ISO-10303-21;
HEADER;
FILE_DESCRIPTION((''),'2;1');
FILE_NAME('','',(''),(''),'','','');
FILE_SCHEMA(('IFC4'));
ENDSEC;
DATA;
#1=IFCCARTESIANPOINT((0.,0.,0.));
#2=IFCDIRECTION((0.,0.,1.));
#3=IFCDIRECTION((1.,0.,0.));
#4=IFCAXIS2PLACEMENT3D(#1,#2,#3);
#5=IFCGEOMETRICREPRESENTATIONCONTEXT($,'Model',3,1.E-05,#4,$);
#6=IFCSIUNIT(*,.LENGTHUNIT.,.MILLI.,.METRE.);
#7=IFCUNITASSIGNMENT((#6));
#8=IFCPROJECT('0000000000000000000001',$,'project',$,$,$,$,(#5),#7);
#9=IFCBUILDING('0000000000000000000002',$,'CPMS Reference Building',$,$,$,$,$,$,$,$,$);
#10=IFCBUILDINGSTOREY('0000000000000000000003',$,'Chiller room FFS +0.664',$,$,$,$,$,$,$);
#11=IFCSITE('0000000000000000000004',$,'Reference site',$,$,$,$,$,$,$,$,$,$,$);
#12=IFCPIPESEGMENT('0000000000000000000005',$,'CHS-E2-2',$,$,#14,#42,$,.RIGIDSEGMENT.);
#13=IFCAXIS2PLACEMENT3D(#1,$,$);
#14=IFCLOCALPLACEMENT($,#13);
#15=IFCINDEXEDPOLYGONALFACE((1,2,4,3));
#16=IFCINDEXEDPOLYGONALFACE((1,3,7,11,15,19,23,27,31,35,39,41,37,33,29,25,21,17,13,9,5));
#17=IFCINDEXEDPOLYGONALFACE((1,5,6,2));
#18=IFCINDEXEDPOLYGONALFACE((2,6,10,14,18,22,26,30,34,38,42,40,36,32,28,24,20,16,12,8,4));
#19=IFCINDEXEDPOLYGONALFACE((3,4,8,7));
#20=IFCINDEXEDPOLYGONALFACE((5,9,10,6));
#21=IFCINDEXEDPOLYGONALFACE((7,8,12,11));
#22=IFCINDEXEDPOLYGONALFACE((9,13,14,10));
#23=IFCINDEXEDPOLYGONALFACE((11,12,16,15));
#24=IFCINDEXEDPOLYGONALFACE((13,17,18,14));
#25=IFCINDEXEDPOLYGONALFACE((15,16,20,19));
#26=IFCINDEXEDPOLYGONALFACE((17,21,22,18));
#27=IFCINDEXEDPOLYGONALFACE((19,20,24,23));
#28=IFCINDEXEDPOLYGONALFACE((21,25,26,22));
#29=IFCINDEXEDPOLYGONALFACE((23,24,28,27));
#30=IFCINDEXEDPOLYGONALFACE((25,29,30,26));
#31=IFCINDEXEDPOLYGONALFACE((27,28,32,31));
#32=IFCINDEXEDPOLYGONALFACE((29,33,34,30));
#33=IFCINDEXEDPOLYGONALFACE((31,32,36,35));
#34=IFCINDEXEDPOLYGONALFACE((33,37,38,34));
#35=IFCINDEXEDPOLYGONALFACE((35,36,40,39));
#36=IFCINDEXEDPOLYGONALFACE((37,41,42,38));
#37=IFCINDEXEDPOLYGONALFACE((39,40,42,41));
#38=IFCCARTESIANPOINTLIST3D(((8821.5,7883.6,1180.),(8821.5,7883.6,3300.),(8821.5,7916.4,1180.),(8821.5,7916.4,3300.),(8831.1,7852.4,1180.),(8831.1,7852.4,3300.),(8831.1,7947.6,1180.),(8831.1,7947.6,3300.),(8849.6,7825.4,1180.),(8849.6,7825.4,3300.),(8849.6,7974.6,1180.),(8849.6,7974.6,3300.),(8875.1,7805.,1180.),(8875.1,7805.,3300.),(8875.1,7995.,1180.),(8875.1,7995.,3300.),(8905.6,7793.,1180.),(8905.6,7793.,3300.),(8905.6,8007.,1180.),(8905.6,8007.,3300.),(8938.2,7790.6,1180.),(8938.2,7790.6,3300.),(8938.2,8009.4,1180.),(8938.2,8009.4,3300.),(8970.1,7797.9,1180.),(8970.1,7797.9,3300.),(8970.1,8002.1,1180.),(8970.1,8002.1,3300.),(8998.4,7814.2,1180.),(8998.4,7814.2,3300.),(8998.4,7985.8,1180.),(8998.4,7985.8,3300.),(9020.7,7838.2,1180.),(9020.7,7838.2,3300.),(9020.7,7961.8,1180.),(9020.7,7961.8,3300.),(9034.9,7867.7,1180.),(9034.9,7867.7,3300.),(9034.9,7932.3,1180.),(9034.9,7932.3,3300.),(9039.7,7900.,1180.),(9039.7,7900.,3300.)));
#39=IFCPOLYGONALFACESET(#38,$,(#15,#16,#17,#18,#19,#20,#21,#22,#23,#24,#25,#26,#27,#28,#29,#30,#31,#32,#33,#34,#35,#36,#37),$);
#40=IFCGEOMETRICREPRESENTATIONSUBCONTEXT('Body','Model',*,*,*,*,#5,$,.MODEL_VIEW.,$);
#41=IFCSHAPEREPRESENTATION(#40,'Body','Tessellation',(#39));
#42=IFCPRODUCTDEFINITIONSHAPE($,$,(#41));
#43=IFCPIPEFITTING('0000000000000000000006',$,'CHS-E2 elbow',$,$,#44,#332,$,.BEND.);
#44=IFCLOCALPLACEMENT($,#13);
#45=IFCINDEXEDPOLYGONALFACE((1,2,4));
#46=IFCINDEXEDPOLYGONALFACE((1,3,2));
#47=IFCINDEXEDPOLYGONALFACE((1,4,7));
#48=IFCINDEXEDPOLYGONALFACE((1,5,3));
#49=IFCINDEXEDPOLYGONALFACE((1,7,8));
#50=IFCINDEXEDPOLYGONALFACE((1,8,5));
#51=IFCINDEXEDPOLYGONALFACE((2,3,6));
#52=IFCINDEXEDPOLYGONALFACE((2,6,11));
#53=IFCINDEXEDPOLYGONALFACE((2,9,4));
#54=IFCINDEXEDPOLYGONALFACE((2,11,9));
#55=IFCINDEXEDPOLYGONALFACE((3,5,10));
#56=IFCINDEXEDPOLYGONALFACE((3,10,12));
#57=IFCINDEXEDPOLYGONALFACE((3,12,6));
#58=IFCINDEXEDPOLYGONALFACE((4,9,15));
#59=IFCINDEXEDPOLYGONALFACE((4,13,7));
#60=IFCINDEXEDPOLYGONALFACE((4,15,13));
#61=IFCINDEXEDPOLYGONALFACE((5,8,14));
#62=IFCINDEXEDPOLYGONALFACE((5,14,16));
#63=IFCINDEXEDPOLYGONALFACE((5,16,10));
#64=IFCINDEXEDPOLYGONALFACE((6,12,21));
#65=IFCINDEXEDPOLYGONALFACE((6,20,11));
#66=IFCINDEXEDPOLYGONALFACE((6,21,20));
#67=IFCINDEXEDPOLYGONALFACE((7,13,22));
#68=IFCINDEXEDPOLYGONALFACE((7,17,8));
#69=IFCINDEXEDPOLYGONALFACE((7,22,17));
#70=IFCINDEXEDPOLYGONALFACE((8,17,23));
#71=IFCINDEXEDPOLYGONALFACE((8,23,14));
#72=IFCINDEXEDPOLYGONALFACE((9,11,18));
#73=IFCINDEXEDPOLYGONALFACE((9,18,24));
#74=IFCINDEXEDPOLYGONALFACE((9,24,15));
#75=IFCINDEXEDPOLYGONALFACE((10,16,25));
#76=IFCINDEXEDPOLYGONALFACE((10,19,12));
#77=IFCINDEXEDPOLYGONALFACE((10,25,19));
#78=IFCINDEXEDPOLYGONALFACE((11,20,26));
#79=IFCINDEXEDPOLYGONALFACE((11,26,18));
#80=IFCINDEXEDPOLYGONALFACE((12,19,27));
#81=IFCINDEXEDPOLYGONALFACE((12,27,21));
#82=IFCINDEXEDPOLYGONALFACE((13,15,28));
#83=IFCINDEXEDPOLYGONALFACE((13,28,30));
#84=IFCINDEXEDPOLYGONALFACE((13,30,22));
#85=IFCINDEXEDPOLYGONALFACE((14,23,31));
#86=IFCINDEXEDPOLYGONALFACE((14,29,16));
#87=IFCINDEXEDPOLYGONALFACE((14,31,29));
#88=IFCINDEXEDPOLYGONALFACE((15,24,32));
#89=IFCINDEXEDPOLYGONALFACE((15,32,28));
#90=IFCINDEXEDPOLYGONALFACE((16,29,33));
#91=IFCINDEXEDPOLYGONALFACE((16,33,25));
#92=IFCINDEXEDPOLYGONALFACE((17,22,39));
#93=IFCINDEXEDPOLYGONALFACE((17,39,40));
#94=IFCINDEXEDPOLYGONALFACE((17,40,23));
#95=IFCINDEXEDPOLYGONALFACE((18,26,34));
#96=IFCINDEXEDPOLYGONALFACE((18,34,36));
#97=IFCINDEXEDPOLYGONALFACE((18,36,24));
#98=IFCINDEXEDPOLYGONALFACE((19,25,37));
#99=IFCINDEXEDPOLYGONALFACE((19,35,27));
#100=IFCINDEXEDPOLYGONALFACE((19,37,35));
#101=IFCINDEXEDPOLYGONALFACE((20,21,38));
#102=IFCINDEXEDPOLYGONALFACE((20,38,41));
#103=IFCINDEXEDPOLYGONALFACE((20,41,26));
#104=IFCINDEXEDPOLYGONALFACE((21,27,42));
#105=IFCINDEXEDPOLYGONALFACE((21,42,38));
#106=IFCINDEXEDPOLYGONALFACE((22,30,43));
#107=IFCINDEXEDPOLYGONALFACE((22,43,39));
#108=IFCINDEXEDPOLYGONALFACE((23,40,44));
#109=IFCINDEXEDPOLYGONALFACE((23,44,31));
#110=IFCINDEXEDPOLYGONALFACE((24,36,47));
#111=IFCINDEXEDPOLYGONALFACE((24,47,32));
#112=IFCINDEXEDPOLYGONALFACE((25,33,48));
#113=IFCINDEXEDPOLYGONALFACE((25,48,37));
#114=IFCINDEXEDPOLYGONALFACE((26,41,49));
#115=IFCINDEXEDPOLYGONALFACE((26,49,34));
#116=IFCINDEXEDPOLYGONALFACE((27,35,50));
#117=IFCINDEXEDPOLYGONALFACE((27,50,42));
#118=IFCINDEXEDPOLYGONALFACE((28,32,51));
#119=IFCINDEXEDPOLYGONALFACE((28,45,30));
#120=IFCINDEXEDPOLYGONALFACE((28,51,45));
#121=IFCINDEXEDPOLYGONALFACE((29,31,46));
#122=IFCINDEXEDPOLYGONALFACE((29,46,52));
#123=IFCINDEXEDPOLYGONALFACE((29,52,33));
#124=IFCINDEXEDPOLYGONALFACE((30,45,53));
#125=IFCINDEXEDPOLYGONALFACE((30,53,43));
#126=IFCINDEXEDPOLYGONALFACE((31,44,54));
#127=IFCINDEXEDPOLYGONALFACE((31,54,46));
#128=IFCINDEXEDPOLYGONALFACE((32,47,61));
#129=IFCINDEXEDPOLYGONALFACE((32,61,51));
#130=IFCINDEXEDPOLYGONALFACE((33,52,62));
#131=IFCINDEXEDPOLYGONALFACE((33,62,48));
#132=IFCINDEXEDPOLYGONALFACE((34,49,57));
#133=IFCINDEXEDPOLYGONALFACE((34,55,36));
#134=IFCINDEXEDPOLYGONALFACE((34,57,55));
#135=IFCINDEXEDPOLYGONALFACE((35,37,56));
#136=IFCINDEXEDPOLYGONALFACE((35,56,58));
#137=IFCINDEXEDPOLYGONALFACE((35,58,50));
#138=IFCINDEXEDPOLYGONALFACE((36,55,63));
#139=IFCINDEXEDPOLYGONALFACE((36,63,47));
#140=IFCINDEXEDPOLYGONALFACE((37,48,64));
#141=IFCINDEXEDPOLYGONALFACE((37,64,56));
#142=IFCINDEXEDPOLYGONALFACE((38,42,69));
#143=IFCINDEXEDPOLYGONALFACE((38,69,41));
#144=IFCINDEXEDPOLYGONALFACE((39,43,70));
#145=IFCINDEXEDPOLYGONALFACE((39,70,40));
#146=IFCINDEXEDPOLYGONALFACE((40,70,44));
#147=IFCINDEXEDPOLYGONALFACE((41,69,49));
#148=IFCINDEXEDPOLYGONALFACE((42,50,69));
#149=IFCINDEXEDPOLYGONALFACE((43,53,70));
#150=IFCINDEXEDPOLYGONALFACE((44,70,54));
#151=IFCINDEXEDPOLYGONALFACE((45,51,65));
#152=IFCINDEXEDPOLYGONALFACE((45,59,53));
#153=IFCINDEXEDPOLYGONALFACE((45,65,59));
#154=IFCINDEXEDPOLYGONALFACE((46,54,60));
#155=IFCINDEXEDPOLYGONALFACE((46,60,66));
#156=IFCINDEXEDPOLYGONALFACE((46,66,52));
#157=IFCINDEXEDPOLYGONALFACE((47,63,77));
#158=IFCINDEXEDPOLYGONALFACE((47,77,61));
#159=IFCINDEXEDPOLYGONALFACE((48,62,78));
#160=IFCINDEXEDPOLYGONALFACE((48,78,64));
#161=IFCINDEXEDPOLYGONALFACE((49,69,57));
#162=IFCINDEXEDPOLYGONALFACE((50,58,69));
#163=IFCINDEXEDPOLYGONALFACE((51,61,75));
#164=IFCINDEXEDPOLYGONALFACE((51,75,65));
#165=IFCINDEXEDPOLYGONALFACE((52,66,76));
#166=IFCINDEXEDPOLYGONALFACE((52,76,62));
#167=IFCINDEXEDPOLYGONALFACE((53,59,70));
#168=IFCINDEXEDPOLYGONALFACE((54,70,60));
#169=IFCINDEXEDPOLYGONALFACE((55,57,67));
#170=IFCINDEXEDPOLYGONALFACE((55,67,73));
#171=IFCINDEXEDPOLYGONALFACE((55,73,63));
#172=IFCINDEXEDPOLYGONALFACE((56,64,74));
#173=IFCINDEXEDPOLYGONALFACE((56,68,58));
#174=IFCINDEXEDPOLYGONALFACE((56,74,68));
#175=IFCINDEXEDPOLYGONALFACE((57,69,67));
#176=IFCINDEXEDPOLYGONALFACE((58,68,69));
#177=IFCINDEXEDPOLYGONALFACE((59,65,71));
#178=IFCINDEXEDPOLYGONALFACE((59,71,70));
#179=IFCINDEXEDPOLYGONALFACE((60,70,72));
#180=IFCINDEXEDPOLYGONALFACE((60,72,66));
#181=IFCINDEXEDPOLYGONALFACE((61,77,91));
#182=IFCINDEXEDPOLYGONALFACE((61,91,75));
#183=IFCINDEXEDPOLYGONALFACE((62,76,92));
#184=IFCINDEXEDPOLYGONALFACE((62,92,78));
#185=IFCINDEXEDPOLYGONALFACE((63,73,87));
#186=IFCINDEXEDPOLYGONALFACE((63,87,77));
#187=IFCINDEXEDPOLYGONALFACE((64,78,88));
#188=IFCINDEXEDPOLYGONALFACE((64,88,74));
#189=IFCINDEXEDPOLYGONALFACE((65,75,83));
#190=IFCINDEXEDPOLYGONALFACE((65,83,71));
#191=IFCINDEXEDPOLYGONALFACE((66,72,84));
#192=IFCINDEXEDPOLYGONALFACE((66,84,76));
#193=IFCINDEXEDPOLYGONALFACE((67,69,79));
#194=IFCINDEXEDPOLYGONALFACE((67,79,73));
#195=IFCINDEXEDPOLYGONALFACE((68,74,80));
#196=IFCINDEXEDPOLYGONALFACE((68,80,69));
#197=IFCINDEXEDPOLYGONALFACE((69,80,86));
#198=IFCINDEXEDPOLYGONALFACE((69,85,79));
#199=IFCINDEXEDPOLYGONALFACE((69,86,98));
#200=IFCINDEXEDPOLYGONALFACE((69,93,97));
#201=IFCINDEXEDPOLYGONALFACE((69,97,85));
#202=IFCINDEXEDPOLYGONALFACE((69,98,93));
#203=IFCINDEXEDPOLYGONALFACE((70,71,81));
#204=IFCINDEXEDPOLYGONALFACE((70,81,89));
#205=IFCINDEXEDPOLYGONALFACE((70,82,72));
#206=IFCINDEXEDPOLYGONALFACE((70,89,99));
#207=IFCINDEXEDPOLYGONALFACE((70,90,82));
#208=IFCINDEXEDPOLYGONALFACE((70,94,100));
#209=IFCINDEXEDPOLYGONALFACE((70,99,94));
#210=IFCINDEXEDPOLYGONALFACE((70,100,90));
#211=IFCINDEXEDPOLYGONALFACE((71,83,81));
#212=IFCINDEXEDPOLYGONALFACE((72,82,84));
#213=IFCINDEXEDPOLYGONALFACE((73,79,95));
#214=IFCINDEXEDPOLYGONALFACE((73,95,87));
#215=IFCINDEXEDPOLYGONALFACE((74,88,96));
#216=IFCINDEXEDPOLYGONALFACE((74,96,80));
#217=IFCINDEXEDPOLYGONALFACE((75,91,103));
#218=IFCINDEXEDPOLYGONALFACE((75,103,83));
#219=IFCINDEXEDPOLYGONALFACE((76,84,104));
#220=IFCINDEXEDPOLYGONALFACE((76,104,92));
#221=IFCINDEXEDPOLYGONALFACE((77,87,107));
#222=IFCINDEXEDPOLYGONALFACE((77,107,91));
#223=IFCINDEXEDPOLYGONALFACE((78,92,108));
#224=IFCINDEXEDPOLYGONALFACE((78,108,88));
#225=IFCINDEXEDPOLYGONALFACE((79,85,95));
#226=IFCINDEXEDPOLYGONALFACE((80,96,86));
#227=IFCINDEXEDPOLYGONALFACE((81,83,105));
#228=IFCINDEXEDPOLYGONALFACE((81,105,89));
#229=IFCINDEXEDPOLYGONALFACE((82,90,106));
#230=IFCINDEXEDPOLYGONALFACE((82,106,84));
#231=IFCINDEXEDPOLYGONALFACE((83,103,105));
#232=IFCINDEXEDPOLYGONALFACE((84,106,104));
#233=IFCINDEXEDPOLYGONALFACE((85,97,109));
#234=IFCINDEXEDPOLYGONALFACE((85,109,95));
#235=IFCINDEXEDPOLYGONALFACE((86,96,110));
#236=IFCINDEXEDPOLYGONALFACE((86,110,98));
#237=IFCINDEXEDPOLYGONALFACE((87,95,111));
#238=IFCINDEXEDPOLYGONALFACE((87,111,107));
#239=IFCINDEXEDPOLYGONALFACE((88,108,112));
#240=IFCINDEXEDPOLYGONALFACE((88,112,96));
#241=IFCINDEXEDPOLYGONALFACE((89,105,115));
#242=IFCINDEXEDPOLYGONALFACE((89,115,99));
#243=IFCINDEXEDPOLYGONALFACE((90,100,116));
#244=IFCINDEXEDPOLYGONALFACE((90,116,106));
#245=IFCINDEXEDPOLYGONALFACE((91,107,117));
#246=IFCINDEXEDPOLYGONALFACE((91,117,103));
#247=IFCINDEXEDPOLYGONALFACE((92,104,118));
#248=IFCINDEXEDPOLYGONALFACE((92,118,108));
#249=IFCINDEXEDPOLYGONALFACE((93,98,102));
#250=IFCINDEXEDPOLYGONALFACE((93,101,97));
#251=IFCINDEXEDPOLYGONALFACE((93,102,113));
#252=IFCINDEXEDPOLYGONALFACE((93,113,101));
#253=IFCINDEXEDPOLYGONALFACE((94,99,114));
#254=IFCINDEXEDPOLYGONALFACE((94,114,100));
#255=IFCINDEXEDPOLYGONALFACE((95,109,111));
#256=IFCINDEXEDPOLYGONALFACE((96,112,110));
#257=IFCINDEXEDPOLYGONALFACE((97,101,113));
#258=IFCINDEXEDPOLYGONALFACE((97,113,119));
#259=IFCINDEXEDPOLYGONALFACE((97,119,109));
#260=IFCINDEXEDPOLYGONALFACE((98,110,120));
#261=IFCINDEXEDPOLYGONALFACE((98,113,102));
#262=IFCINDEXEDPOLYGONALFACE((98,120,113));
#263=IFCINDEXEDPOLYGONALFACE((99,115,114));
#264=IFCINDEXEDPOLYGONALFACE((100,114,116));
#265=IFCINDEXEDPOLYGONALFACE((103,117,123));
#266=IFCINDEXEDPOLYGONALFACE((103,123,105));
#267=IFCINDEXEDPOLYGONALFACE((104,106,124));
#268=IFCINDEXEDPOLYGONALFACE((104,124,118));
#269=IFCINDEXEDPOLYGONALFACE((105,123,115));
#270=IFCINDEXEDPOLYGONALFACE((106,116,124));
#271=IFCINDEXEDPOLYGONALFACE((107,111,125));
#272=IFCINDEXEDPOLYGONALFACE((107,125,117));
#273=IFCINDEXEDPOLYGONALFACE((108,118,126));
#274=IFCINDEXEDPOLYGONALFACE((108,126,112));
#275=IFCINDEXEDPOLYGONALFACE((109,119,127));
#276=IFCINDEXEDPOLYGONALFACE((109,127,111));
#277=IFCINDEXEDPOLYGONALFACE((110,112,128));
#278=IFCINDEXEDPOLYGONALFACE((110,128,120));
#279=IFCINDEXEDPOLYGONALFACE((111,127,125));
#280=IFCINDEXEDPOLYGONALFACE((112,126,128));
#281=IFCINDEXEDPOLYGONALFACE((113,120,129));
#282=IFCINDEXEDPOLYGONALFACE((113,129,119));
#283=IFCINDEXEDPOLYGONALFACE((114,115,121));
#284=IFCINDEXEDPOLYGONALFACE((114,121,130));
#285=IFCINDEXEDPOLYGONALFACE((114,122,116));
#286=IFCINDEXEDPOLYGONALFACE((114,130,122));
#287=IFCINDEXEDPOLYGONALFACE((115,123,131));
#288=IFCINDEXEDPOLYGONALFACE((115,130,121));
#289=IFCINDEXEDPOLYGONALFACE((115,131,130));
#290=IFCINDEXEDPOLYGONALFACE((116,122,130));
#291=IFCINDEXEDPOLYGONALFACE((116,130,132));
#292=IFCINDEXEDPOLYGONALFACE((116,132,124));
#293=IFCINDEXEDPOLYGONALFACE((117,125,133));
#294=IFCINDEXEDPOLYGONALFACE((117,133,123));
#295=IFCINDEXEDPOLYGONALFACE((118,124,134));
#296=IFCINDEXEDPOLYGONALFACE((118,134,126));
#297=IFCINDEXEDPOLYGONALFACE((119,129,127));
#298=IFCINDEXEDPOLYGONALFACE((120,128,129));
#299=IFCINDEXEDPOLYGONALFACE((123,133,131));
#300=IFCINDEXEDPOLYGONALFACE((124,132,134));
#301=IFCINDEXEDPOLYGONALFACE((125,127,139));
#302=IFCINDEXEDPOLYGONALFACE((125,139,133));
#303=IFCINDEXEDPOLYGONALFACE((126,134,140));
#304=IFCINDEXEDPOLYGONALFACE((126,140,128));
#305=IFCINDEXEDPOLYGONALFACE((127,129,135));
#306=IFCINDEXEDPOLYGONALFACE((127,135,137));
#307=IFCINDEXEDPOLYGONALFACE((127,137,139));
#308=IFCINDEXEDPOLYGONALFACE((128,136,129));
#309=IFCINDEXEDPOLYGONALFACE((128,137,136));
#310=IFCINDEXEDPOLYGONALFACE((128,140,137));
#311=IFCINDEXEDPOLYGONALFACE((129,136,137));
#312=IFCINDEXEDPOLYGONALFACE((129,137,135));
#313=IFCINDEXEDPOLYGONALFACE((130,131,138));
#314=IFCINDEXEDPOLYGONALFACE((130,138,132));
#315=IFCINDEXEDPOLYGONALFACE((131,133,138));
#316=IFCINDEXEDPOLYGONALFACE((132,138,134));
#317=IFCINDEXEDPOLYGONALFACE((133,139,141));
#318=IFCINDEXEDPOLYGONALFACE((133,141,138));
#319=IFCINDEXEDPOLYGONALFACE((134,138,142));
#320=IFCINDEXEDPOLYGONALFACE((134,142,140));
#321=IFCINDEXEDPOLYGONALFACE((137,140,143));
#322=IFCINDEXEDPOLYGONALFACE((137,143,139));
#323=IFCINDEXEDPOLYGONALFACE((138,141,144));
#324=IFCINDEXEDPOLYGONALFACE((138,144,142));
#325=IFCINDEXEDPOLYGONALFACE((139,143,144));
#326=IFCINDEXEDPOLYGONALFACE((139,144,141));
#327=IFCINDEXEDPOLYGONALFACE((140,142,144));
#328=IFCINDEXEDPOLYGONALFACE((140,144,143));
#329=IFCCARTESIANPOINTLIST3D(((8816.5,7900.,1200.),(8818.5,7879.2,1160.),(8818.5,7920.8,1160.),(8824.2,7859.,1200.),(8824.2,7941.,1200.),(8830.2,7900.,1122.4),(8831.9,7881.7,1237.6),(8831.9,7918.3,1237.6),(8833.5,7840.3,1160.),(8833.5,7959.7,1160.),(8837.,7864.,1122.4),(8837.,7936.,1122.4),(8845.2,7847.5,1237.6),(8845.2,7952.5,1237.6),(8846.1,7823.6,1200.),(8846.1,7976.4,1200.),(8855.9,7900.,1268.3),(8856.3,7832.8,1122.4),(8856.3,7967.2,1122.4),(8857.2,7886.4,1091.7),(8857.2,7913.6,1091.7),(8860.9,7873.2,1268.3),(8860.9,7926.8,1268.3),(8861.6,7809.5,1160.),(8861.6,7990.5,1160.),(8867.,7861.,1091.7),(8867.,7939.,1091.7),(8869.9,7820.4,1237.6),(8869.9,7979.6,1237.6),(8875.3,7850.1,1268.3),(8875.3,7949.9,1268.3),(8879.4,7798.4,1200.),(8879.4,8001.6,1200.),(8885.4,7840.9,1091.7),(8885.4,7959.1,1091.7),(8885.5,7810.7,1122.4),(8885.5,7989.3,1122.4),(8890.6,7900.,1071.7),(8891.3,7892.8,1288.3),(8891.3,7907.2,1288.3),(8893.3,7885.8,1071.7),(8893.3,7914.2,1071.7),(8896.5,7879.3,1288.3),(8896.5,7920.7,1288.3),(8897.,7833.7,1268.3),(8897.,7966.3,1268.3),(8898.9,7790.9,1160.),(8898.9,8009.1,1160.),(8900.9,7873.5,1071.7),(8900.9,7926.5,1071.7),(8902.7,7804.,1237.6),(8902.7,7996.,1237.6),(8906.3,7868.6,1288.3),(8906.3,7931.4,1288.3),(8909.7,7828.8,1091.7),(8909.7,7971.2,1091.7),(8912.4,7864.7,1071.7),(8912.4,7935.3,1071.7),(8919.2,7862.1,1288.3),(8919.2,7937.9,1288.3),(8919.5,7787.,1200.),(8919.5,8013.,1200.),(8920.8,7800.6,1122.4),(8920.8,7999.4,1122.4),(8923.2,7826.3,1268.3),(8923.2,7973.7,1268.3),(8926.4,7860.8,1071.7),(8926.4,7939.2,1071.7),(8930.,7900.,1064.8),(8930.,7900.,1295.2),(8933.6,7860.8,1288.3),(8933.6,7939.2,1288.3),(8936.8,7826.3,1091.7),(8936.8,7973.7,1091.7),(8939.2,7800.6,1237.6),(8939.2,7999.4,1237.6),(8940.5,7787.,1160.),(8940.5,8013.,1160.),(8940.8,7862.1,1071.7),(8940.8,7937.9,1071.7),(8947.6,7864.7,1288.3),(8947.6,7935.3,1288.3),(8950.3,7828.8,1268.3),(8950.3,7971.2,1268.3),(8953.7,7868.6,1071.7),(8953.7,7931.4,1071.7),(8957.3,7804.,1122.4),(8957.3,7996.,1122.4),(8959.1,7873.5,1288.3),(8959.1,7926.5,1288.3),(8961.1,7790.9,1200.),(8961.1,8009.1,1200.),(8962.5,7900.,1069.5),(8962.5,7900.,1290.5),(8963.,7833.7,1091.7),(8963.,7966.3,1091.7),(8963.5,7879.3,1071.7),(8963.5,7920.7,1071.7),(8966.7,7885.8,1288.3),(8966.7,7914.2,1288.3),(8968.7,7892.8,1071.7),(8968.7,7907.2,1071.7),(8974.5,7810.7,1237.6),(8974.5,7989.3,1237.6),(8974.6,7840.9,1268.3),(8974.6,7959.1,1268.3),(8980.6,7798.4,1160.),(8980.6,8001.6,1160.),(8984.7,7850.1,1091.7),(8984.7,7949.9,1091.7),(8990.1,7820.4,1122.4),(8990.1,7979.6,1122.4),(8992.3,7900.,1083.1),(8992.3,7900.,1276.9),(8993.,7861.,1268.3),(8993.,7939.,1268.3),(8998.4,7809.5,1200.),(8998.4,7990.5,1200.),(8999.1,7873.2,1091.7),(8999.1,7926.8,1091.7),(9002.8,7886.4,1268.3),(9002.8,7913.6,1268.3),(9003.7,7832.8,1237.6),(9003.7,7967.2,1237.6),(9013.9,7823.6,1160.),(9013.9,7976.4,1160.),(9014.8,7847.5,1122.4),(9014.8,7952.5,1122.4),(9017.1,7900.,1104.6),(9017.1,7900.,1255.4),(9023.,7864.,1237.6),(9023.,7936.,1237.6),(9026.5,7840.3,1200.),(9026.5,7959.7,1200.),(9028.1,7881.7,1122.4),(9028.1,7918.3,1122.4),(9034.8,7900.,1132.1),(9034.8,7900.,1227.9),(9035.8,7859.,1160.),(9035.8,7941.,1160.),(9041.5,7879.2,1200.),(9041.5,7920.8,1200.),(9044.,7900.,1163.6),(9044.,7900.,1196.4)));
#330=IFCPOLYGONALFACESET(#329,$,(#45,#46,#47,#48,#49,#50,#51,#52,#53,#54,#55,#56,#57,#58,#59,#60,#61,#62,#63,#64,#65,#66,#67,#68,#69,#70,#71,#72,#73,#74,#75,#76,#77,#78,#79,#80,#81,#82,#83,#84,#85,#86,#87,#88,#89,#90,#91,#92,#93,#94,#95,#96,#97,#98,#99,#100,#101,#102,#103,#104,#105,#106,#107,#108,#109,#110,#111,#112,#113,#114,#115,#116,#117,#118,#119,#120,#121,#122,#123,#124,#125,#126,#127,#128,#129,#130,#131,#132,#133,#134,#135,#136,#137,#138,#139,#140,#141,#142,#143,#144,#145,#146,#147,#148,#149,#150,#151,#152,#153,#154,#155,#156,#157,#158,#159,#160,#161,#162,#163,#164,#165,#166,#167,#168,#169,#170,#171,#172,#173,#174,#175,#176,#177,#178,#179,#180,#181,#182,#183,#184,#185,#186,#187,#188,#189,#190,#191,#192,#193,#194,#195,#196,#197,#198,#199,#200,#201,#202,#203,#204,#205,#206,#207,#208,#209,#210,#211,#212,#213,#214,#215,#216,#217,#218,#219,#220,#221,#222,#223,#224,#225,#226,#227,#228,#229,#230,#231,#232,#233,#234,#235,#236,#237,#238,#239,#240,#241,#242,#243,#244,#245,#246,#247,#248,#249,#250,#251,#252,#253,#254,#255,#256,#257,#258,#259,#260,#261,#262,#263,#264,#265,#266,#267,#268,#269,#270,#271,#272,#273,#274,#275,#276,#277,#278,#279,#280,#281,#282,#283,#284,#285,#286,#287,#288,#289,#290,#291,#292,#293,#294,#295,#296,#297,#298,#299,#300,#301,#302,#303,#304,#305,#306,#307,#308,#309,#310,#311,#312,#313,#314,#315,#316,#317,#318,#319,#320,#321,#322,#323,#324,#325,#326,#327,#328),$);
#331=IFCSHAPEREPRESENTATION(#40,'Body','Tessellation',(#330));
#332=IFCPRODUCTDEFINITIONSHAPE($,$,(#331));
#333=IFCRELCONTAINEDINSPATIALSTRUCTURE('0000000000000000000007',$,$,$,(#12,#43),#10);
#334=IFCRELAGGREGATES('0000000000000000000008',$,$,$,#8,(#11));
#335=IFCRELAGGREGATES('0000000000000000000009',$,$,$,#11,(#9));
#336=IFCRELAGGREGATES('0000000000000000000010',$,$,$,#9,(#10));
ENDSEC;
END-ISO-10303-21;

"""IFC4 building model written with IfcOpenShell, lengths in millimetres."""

from ifc_helpers import new_model, entity, si_unit, frame, origin_with_axes, origin_2d, place, context, subcontext, project, spatial, circle_curve, outline, extrude, element, save


model = new_model("IFC4")

# Units and contexts
model_context = context("Model", 3, precision=1e-05, world=origin_with_axes())
body_context = subcontext(model_context, "Body", "Model", "MODEL_VIEW")
ifc_project = project(units=[si_unit("LENGTHUNIT", "METRE", prefix="MILLI")], contexts=[model_context])

# Site, building, storey
site = spatial("IfcSite", under=ifc_project, Name="Reference site")
building = spatial("IfcBuilding", under=site, Name="CPMS Reference Building")
storey = spatial("IfcBuildingStorey", under=building, Name="Chiller room FFS +0.664")

# Pipe segment
pipe_segment_1_placement = place(None, origin_with_axes())
element("IfcPipeSegment", 1, at=pipe_segment_1_placement, inside=storey, Name="CHS-E2-2", PredefinedType="RIGIDSEGMENT", context=body_context, shape_type="SweptSolid", body=[
    extrude(outline(circle_curve(origin_2d(), 109.7)), frame((8930.0, 7900.0, 1180.0), z_axis=(0.0, 0.0, 1.0), x_axis=(1.0, 0.0, 0.0)), (0.0, 0.0, 1.0), 2120.0),
])

# Pipe fitting
pipe_fitting_1_placement = place(None, origin_with_axes())
element("IfcPipeFitting", 2, at=pipe_fitting_1_placement, inside=storey, Name="CHS-E2 elbow", PredefinedType="BEND", context=body_context, shape_type="CSG", body=[
    entity("IfcSphere", entity("IfcAxis2Placement3D", entity("IfcCartesianPoint", [8930.0, 7900.0, 1180.0]), entity("IfcDirection", [0.0, 0.0, 1.0]), entity("IfcDirection", [1.0, 0.0, 0.0])), 115.2),
])

save(model, "model.ifc")
